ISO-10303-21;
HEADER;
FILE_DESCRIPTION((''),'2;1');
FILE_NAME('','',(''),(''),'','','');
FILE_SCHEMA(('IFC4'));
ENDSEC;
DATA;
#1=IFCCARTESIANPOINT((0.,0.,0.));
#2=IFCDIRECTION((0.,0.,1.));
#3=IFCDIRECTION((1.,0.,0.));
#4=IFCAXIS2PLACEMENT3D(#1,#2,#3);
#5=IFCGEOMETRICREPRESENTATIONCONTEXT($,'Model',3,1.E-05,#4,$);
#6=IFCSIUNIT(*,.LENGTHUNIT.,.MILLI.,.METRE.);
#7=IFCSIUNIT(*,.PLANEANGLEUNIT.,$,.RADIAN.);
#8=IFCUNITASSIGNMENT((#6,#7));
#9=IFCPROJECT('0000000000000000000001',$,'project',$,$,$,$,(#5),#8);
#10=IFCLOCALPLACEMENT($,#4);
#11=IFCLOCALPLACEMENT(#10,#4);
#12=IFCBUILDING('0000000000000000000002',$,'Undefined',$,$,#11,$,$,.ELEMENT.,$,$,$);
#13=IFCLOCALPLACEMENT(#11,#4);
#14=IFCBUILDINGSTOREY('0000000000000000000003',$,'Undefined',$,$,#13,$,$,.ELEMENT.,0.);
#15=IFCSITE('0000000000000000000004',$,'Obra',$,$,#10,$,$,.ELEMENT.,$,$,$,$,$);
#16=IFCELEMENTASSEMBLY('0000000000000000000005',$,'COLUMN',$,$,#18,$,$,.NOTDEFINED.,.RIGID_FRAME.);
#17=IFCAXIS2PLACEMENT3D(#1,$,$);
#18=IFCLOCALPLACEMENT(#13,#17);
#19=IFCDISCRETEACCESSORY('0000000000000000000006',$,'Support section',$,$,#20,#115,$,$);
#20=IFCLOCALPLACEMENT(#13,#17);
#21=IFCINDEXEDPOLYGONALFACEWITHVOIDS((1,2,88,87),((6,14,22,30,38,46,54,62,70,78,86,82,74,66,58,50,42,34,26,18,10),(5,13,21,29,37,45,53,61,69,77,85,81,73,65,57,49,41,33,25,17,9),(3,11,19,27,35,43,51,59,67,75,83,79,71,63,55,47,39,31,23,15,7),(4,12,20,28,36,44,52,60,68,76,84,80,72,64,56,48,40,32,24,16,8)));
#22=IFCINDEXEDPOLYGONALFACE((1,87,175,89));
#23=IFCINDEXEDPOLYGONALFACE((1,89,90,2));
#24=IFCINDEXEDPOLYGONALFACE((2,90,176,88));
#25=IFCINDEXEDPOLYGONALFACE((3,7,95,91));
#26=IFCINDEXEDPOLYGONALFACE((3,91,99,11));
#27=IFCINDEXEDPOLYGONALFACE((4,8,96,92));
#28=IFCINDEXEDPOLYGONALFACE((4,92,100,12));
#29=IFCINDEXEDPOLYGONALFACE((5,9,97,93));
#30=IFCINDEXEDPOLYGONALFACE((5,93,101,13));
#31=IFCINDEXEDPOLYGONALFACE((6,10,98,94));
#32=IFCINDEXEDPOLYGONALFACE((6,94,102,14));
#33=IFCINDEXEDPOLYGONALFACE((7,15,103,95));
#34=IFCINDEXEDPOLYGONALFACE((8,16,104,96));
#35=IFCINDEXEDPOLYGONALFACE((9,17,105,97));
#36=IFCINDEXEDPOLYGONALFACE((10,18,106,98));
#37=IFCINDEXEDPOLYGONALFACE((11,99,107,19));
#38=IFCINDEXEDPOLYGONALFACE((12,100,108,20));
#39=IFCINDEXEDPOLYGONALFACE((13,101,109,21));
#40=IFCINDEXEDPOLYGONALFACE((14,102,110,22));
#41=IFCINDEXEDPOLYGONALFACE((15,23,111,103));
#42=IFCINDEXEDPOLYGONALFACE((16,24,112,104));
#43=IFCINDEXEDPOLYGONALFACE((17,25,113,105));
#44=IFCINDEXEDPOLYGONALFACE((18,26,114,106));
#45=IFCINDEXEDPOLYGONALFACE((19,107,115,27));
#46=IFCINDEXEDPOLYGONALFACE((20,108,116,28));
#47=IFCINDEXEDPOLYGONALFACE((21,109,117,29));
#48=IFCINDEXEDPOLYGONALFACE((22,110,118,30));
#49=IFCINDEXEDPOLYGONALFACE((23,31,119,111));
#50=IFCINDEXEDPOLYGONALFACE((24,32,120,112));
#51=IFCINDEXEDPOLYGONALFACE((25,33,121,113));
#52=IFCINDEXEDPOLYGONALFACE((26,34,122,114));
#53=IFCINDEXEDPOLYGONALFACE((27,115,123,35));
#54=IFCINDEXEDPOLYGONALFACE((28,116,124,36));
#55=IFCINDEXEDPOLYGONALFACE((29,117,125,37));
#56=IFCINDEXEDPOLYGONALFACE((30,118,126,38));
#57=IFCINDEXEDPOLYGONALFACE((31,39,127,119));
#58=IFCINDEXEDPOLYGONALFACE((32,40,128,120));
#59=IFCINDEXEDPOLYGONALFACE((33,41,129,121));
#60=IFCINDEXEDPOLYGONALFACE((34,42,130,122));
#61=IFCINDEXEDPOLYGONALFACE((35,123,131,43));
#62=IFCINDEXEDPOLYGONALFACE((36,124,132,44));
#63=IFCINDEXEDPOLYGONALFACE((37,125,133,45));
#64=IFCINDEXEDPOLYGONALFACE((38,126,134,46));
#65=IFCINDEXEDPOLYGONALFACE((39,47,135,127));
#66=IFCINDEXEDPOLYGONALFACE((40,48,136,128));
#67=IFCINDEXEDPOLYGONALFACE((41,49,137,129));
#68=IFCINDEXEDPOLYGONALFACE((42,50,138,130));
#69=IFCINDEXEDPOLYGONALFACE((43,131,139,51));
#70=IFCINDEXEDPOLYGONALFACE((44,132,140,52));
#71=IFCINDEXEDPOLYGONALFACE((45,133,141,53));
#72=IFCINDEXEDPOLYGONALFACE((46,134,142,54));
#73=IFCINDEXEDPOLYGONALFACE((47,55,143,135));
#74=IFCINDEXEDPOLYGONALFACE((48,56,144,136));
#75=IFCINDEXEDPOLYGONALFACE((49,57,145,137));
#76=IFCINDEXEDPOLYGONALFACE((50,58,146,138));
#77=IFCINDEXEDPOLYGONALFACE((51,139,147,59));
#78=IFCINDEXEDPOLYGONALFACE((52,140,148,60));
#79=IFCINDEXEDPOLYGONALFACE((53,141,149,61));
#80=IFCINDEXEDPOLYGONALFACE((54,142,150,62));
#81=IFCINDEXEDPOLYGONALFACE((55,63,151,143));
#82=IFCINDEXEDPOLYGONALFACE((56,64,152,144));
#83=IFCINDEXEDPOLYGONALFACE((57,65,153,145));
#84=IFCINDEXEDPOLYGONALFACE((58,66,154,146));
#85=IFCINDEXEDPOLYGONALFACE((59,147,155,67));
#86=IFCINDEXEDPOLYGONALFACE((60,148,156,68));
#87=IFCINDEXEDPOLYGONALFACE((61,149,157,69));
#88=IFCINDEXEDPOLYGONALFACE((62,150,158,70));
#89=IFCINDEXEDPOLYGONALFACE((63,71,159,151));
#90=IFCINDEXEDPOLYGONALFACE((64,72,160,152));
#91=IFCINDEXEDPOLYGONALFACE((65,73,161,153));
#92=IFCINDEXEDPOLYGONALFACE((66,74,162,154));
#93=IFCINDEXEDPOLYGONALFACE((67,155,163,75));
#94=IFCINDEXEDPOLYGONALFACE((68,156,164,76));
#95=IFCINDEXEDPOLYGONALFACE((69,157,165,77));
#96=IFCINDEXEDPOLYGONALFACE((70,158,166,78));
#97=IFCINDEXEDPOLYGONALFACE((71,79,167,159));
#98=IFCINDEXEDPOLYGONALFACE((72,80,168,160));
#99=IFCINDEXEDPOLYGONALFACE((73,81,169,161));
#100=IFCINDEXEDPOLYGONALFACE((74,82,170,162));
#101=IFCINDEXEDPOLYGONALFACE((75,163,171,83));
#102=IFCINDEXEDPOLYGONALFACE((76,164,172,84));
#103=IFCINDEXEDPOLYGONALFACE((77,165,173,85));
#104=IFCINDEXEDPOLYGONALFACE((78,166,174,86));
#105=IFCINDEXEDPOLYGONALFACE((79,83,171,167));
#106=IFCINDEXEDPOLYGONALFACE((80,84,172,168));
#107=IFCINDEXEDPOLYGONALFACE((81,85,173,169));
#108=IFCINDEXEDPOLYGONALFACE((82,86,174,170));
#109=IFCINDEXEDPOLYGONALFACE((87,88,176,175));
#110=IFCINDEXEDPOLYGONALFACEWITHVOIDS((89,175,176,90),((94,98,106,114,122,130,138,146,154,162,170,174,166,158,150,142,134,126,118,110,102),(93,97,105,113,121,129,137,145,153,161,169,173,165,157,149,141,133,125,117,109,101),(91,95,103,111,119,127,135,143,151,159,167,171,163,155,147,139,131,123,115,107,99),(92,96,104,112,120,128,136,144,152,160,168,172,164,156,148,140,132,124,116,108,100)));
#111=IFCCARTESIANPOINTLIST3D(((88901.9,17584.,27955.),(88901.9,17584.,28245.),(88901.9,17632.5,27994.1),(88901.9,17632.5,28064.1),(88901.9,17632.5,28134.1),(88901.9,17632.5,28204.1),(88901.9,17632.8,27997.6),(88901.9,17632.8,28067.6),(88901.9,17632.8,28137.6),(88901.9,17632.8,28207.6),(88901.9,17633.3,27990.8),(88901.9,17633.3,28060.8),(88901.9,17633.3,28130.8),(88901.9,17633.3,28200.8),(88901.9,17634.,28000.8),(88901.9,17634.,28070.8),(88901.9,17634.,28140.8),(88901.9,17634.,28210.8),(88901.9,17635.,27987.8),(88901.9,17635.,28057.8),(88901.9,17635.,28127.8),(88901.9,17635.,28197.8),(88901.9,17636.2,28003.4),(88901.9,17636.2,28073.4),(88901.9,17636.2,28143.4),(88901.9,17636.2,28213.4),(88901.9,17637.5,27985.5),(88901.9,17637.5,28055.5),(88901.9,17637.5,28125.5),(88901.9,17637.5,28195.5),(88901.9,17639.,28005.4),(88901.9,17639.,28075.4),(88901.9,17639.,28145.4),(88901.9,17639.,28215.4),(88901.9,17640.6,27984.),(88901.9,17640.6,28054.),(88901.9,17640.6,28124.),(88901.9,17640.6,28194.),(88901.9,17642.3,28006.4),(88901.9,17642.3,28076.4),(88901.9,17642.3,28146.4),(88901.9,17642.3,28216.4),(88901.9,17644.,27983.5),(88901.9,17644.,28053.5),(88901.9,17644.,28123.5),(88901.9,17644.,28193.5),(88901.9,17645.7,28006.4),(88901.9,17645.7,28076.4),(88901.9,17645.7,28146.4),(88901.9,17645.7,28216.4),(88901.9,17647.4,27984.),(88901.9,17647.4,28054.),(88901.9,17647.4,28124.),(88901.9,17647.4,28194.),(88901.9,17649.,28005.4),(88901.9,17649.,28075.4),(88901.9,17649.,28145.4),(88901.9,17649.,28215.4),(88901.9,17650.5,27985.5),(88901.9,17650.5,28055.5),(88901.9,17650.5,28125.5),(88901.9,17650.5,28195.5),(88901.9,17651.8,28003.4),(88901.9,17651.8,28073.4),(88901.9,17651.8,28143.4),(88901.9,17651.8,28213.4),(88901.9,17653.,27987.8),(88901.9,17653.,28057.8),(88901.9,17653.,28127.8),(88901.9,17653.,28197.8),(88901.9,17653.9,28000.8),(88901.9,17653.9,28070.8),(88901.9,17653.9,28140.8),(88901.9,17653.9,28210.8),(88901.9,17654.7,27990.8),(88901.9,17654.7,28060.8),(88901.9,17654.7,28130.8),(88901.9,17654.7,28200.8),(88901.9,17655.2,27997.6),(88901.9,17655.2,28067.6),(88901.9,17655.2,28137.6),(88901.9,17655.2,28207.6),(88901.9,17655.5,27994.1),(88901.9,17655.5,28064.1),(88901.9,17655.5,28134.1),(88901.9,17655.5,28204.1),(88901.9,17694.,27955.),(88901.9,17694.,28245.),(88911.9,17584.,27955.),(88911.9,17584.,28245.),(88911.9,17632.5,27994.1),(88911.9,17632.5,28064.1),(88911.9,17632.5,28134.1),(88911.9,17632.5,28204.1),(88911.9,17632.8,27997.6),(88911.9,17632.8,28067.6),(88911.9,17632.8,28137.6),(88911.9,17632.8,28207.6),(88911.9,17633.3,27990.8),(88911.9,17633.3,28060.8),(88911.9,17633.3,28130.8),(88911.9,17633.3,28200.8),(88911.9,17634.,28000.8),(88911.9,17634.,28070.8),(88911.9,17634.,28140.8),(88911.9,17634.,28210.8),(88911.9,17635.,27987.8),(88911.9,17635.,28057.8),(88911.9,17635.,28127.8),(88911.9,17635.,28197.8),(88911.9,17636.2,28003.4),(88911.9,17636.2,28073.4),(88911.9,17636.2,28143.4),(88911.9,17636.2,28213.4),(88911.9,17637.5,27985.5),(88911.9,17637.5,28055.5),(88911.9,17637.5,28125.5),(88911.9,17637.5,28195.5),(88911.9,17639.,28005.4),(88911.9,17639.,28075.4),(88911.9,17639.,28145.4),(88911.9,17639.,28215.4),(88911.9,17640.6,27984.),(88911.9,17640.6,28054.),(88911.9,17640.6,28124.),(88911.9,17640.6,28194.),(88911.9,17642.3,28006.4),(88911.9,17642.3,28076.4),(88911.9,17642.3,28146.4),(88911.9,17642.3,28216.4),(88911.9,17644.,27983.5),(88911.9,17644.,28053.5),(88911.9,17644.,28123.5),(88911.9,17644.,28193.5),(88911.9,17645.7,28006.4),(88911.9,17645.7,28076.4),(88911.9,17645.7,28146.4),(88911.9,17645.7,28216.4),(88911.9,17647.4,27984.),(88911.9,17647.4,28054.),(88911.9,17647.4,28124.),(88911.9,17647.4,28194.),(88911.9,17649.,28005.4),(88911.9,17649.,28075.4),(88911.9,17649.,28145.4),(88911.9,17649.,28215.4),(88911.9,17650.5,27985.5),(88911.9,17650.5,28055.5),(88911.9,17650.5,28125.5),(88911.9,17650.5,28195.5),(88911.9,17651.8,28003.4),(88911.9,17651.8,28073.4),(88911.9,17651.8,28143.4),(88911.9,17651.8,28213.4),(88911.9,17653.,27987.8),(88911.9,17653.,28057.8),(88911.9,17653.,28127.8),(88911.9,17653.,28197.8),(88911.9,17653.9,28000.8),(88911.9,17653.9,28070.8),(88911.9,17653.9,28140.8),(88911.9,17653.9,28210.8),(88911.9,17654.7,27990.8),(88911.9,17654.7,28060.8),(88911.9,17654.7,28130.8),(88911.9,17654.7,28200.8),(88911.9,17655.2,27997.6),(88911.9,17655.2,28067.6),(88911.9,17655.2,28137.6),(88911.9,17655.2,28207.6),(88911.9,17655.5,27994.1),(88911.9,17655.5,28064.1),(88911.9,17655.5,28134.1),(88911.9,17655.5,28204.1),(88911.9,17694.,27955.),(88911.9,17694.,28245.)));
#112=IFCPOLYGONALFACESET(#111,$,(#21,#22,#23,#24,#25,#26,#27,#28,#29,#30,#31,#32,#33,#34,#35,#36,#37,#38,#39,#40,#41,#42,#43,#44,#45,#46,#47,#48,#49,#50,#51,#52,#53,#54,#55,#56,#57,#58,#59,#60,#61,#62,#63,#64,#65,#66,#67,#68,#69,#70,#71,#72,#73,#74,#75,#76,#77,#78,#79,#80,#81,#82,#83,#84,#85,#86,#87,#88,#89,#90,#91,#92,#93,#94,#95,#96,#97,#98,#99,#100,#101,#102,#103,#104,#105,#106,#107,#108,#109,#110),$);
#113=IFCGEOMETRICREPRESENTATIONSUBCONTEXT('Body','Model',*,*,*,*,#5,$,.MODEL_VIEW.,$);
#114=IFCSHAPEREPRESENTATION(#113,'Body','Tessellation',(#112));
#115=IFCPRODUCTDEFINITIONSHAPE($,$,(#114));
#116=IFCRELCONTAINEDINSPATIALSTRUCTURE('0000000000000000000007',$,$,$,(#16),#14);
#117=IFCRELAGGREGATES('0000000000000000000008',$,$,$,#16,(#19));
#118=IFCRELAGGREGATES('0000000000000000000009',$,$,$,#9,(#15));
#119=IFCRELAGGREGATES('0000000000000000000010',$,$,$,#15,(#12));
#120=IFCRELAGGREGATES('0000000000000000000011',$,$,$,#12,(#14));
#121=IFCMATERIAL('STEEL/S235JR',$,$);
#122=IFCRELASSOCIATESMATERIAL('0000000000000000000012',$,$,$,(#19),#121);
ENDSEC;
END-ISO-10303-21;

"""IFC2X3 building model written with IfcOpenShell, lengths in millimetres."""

from ifc_helpers import new_model, si_unit, frame, origin_with_axes, origin_2d_with_axis, place, context, subcontext, project, spatial, rectangle, circle, extrude, source, transform, mapped, material, element, aggregate, save


model = new_model("IFC2X3")

# Units and contexts
model_context = context("Model", 3, precision=1e-05, world=origin_with_axes())
body_context = subcontext(model_context, "Body", "Model", "MODEL_VIEW")
ifc_project = project(units=[si_unit("LENGTHUNIT", "METRE", prefix="MILLI"), si_unit("PLANEANGLEUNIT", "RADIAN")], contexts=[model_context])

# Site, building, storey
site_placement = place(None, origin_with_axes())
site = spatial("IfcSite", under=ifc_project, at=site_placement, Name="Obra", CompositionType="ELEMENT")
building_placement = place(site_placement, origin_with_axes())
building = spatial("IfcBuilding", under=site, at=building_placement, Name="Undefined", CompositionType="ELEMENT")
storey_placement = place(building_placement, origin_with_axes())
storey = spatial("IfcBuildingStorey", under=building, at=storey_placement, Name="Undefined", CompositionType="ELEMENT", Elevation=0.0)

# Shared definitions
ifc_material = material(Name="STEEL/S235JR")

# Shared definitions
shared_shape_1 = source(origin_with_axes(), body_context, "Body", "SweptSolid", [
    extrude(circle(Radius=11.5, at=origin_2d_with_axis()), frame((0.0, -14.4, 0.0), z_axis=(0.0, 1.0, 0.0), x_axis=(1.0, 0.0, 0.0)), (0.0, 0.0, 1.0), 10.2),
])

# Element assembly, discrete accessory, opening
assembly_1_placement = place(storey_placement, origin_with_axes())
assembly_1 = element("IfcElementAssembly", 1, at=assembly_1_placement, inside=storey, Name="COLUMN", AssemblyPlace="NOTDEFINED", PredefinedType="RIGID_FRAME")
discrete_accessory_1_placement = place(assembly_1_placement, frame((88906.9, 17639.0, 27955.0), z_axis=(0.0, 0.0, 1.0), x_axis=(0.0, -1.0, 0.0)))
discrete_accessory_1 = element("IfcDiscreteAccessory", 2, at=discrete_accessory_1_placement, material=ifc_material, Name="Support section", context=body_context, shape_type="SweptSolid", body=[
    extrude(rectangle(XDim=10.0, YDim=110.0, at=origin_2d_with_axis()), frame((0.0, 0.0, 290.0), z_axis=(0.0, 0.0, -1.0), x_axis=(0.0, 1.0, 0.0)), (0.0, 0.0, 1.0), 290.0),
])
opening_1_placement = place(assembly_1_placement, frame((88897.6, 17594.0, 28300.0), z_axis=(0.0, 1.0, 0.0), x_axis=(0.0, 0.0, -1.0)))
element("IfcOpeningElement", 3, at=opening_1_placement, cuts=discrete_accessory_1, ObjectType="Opening", context=body_context, shape_type="MappedRepresentation", body=[
    mapped(shared_shape_1, transform((95.0, 0.0, 50.0))),
    mapped(shared_shape_1, transform((165.0, 0.0, 50.0))),
    mapped(shared_shape_1, transform((235.0, 0.0, 50.0))),
    mapped(shared_shape_1, transform((305.0, 0.0, 50.0))),
])
aggregate(assembly_1, [discrete_accessory_1])

save(model, "model.ifc")
